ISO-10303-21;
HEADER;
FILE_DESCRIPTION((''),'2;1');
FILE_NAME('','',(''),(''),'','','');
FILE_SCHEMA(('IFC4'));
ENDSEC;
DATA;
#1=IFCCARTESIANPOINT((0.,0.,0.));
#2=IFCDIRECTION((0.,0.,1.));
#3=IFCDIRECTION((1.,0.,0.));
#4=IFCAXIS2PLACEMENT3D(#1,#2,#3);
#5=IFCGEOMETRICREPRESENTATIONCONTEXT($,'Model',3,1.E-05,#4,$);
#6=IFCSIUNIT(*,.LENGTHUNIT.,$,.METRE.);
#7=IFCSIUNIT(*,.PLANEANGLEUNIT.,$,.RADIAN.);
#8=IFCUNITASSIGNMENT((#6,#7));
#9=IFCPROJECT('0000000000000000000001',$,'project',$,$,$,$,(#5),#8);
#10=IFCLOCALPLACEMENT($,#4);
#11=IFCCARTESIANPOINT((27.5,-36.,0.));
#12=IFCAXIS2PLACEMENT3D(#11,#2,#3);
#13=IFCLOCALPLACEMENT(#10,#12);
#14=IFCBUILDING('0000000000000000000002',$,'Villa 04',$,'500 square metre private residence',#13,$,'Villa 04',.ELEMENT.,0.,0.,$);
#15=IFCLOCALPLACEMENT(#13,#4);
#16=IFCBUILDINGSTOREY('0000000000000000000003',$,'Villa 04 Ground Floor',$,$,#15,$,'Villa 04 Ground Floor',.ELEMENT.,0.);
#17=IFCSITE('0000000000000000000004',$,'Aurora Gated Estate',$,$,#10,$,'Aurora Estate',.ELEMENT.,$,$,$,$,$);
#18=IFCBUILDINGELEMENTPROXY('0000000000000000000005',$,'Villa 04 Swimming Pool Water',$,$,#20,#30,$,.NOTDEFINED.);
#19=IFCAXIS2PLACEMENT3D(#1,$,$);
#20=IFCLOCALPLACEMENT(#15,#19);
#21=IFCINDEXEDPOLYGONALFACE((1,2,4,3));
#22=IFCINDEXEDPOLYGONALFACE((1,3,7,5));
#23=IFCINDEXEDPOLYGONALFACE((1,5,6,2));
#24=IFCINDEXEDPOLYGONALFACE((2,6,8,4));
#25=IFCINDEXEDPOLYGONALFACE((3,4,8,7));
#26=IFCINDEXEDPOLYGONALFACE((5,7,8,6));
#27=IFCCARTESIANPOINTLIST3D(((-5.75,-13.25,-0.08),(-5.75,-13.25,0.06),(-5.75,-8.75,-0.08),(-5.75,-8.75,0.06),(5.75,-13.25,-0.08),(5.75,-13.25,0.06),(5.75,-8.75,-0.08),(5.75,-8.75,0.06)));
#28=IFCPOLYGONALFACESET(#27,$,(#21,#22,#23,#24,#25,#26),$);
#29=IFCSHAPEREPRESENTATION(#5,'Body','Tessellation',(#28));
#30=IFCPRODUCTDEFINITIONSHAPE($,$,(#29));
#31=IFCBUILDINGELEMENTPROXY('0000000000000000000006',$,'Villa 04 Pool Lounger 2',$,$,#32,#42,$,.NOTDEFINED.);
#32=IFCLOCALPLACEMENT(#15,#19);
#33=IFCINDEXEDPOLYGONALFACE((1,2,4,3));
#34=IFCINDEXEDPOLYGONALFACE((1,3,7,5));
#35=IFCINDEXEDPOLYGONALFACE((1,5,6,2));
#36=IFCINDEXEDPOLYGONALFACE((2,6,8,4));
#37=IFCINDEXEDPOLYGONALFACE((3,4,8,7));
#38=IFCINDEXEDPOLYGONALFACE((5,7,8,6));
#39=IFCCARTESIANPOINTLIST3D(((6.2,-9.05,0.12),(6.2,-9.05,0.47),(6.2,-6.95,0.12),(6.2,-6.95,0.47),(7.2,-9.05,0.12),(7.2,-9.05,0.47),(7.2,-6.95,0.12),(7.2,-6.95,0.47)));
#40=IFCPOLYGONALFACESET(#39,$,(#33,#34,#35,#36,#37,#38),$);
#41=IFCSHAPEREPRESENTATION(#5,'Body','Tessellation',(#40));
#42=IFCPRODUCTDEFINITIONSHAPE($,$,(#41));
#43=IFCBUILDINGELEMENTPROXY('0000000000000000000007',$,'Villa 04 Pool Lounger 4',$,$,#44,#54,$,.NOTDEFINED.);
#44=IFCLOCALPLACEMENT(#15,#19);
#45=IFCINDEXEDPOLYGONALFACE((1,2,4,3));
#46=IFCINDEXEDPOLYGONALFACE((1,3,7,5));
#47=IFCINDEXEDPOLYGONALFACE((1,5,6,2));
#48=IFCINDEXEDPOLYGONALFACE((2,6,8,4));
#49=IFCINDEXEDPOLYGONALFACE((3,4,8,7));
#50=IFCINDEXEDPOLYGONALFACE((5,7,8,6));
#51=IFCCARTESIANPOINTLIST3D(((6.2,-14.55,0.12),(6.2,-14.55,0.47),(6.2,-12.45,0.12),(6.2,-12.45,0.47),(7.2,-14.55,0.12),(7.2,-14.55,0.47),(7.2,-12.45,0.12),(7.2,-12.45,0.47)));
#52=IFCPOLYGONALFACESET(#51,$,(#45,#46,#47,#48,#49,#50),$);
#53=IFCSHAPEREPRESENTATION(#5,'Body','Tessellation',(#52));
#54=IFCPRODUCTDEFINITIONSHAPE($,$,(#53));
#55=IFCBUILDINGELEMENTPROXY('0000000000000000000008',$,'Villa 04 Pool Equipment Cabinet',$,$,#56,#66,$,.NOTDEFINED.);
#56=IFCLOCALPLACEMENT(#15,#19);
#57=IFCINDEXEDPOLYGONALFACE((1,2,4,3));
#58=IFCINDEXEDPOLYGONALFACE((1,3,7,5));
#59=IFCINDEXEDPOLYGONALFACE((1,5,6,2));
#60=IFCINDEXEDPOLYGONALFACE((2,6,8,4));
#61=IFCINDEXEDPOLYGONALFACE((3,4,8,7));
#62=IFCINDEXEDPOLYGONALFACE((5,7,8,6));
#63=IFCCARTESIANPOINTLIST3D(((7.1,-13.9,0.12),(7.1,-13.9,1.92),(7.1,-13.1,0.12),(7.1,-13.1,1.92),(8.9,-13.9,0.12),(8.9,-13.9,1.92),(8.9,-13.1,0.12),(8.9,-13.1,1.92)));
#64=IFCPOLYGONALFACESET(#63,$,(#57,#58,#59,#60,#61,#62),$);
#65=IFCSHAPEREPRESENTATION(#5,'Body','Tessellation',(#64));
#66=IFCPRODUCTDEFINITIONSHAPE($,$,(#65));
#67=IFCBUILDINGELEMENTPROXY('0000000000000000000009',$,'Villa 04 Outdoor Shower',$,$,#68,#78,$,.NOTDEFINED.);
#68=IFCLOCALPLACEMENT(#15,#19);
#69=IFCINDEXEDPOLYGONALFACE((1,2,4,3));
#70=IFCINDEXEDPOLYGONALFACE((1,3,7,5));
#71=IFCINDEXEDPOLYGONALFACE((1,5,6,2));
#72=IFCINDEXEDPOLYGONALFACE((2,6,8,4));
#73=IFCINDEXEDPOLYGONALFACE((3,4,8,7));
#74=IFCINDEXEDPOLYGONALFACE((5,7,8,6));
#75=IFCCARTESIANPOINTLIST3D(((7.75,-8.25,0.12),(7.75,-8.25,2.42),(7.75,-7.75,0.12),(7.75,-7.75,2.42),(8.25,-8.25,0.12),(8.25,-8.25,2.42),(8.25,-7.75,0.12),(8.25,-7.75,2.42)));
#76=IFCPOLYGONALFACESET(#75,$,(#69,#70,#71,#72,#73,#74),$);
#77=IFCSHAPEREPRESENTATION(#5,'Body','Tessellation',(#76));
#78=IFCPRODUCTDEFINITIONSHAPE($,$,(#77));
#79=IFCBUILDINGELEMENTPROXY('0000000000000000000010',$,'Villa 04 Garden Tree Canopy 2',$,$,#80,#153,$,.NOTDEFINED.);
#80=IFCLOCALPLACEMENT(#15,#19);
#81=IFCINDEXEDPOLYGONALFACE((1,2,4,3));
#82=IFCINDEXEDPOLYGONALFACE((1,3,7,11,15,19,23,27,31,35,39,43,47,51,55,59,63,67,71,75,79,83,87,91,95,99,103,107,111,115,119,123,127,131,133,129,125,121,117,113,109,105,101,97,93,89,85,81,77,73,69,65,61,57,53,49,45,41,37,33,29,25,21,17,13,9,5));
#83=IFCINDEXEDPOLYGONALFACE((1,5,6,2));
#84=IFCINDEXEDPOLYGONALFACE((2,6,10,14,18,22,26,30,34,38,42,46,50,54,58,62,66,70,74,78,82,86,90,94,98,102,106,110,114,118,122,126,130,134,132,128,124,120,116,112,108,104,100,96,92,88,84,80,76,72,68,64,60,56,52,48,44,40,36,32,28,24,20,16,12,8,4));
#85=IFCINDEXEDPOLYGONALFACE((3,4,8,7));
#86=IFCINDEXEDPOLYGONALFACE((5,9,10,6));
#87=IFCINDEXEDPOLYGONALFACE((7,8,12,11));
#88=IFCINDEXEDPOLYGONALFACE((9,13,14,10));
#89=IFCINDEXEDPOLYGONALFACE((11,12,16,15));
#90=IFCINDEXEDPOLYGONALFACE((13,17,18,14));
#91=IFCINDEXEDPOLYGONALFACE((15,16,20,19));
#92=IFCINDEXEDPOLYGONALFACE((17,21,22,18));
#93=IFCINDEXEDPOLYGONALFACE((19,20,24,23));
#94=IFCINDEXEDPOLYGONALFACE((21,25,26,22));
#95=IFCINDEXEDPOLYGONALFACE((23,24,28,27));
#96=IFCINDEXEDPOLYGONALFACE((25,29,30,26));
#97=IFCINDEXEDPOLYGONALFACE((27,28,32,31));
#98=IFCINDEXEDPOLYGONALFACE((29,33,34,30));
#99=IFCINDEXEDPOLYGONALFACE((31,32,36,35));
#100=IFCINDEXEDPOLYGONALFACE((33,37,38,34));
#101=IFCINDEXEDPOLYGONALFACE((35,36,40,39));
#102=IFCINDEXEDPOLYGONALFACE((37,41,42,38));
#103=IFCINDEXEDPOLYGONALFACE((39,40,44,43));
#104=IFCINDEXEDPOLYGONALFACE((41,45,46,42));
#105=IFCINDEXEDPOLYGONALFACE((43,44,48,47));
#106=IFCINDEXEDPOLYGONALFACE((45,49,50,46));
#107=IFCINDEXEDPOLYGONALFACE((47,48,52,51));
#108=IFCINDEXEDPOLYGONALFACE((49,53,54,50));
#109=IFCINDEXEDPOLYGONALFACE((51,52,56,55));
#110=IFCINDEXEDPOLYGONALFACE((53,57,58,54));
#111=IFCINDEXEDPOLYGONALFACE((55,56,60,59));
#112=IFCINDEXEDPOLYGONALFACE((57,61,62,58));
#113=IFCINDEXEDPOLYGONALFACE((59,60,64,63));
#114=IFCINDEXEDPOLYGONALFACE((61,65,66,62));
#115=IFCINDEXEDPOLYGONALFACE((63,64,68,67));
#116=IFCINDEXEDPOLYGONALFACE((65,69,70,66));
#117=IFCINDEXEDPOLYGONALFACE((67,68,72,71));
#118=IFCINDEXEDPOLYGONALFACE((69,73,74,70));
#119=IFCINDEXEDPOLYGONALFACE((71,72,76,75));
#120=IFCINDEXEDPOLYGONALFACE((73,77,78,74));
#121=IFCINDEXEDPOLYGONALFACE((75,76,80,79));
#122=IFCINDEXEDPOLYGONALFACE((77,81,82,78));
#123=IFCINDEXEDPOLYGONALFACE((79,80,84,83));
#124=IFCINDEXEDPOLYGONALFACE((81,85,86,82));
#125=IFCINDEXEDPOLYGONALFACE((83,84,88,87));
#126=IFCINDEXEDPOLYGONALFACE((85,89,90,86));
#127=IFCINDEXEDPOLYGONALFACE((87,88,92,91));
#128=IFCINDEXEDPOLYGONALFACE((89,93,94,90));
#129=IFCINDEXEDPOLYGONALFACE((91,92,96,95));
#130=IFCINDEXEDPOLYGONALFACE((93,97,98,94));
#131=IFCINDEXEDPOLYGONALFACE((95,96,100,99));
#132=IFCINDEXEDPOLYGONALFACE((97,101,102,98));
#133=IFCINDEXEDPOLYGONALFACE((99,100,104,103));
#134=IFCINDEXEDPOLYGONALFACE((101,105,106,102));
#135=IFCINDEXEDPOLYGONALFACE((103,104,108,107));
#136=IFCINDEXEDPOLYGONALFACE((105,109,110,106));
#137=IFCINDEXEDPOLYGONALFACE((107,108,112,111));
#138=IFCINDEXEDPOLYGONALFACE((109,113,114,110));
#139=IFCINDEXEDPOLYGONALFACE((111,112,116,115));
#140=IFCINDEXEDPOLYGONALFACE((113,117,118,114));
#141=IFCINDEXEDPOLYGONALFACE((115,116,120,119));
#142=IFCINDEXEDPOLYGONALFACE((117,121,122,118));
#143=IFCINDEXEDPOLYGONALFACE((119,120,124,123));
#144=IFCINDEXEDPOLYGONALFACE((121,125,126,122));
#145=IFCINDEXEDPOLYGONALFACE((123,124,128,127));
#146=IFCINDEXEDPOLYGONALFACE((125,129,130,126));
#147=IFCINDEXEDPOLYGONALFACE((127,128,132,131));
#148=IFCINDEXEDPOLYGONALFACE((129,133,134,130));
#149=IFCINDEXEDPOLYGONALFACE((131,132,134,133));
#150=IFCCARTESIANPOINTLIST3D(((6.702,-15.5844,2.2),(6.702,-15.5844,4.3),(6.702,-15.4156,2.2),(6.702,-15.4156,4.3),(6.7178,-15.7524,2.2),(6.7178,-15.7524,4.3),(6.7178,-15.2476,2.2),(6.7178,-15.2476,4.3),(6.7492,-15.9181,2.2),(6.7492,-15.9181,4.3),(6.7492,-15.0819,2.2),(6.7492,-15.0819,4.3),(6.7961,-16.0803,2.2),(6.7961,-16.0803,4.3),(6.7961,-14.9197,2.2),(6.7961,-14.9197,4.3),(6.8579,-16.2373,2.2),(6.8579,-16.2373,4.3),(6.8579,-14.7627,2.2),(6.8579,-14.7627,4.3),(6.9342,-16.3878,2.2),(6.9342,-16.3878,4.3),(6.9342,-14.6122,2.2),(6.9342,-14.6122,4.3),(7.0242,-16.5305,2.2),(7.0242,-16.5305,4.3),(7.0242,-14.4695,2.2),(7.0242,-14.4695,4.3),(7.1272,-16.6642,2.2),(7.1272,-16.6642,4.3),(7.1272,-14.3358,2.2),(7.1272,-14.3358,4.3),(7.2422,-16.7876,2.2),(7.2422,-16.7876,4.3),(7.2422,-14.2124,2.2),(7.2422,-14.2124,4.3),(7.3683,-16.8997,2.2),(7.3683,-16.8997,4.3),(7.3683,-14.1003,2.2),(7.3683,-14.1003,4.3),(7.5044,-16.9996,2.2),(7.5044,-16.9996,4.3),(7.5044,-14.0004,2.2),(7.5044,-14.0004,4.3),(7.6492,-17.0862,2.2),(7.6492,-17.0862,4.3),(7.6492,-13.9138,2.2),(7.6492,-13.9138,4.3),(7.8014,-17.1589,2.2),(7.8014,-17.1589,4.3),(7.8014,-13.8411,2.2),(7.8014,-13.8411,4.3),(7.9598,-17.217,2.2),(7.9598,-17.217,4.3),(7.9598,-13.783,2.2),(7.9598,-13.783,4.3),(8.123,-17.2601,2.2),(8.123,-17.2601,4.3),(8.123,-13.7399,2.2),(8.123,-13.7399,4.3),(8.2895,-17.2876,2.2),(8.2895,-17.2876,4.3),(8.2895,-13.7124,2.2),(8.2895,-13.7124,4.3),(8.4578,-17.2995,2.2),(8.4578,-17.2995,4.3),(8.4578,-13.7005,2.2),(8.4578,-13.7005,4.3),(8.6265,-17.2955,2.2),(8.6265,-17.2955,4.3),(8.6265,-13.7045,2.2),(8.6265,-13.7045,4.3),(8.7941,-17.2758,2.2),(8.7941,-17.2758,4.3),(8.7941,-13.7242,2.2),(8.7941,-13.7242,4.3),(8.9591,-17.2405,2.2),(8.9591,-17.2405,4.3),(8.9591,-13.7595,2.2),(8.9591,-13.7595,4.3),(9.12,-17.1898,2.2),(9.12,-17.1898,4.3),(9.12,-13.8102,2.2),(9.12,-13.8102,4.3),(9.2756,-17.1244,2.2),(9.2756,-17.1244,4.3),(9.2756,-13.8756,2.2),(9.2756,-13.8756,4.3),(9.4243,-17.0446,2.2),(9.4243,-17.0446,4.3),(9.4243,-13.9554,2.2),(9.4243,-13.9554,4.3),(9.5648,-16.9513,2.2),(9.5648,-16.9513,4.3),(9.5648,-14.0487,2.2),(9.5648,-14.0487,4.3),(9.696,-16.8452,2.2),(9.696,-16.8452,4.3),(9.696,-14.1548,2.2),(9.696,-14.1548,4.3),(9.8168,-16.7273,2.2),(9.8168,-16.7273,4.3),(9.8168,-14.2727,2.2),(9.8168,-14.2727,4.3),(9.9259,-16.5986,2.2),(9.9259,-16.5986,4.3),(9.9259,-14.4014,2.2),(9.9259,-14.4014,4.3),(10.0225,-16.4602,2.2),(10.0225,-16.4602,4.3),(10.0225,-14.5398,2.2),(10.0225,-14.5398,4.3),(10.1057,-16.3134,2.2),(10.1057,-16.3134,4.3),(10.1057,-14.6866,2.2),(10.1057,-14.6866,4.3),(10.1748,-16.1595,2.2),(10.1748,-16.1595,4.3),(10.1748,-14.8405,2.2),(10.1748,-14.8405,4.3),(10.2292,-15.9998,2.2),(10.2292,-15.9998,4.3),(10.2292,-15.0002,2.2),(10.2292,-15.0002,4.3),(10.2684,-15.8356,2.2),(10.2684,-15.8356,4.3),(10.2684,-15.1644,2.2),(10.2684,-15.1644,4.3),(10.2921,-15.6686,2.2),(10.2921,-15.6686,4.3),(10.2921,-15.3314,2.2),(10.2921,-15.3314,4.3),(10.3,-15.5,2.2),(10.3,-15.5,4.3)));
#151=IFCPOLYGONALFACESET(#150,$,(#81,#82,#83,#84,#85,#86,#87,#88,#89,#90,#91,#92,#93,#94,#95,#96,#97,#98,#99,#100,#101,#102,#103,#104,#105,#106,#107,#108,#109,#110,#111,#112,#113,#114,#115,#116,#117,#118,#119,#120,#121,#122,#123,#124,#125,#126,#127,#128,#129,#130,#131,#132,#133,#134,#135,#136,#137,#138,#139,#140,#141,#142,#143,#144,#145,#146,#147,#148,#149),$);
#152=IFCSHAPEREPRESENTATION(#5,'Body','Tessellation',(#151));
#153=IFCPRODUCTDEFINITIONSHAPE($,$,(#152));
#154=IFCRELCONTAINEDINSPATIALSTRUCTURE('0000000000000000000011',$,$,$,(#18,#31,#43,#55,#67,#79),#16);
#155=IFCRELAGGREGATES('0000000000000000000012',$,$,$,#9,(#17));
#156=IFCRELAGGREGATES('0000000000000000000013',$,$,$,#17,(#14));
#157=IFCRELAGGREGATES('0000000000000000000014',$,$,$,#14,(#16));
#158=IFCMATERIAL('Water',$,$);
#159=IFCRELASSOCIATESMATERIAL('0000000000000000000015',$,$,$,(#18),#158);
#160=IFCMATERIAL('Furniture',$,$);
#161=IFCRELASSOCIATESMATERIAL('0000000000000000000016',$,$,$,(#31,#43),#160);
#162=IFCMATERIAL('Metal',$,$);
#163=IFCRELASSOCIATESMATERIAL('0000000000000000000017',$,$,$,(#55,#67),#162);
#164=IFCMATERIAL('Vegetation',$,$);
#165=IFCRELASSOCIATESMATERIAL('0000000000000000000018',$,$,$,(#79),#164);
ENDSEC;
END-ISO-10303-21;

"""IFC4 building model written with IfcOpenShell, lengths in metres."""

from ifc_helpers import new_model, si_unit, frame, origin_with_axes, origin_2d_with_axis, place, context, project, spatial, rectangle, circle, extrude, material, element, save


model = new_model("IFC4")

# Units and contexts
model_context = context("Model", 3, precision=1e-05, world=origin_with_axes())
ifc_project = project(units=[si_unit("LENGTHUNIT", "METRE"), si_unit("PLANEANGLEUNIT", "RADIAN")], contexts=[model_context])

# Site, building, storey
site_placement = place(None, origin_with_axes())
site = spatial("IfcSite", under=ifc_project, at=site_placement, Name="Aurora Gated Estate", LongName="Aurora Estate", CompositionType="ELEMENT")
building_placement = place(site_placement, frame((27.5, -36.0, 0.0), z_axis=(0.0, 0.0, 1.0), x_axis=(1.0, 0.0, 0.0)))
building = spatial("IfcBuilding", under=site, at=building_placement, Name="Villa 04", ObjectType="500 square metre private residence", LongName="Villa 04", CompositionType="ELEMENT", ElevationOfRefHeight=0.0, ElevationOfTerrain=0.0)
storey_placement = place(building_placement, origin_with_axes())
storey = spatial("IfcBuildingStorey", under=building, at=storey_placement, Name="Villa 04 Ground Floor", LongName="Villa 04 Ground Floor", CompositionType="ELEMENT", Elevation=0.0)

# Building element proxies
ifc_material_1 = material(Name="Furniture")
ifc_material_2 = material(Name="Water")
proxy_1_placement = place(storey_placement, frame((0.0, -11.0, -0.08), z_axis=(0.0, 0.0, 1.0), x_axis=(1.0, 0.0, 0.0)))
element("IfcBuildingElementProxy", 1, at=proxy_1_placement, inside=storey, material=ifc_material_2, Name="Villa 04 Swimming Pool Water", PredefinedType="NOTDEFINED", context=model_context, shape_type="SweptSolid", body=[
    extrude(rectangle(XDim=11.5, YDim=4.5, at=origin_2d_with_axis()), origin_with_axes(), (0.0, 0.0, 1.0), 0.14),
])
for number, where, z_axis, x_axis, name in (
    (2, (6.7, -8.0, 0.12), (0.0, 0.0, 1.0), (1.0, 0.0, 0.0), "Villa 04 Pool Lounger 2"),
    (3, (6.7, -13.5, 0.12), (0.0, 0.0, 1.0), (1.0, 0.0, 0.0), "Villa 04 Pool Lounger 4"),
):
    element("IfcBuildingElementProxy", number, at=place(storey_placement, frame(where, z_axis=z_axis, x_axis=x_axis)), inside=storey, material=ifc_material_1, Name=name, PredefinedType="NOTDEFINED", context=model_context, shape_type="SweptSolid", body=[
        extrude(rectangle(XDim=1.0, YDim=2.1, at=origin_2d_with_axis()), origin_with_axes(), (0.0, 0.0, 1.0), 0.35),
    ])
ifc_material_3 = material(Name="Metal")
proxy_2_placement = place(storey_placement, frame((8.0, -13.5, 0.12), z_axis=(0.0, 0.0, 1.0), x_axis=(1.0, 0.0, 0.0)))
element("IfcBuildingElementProxy", 4, at=proxy_2_placement, inside=storey, material=ifc_material_3, Name="Villa 04 Pool Equipment Cabinet", PredefinedType="NOTDEFINED", context=model_context, shape_type="SweptSolid", body=[
    extrude(rectangle(XDim=1.8, YDim=0.8, at=origin_2d_with_axis()), origin_with_axes(), (0.0, 0.0, 1.0), 1.8),
])
proxy_3_placement = place(storey_placement, frame((8.0, -8.0, 0.12), z_axis=(0.0, 0.0, 1.0), x_axis=(1.0, 0.0, 0.0)))
element("IfcBuildingElementProxy", 5, at=proxy_3_placement, inside=storey, material=ifc_material_3, Name="Villa 04 Outdoor Shower", PredefinedType="NOTDEFINED", context=model_context, shape_type="SweptSolid", body=[
    extrude(rectangle(XDim=0.5, YDim=0.5, at=origin_2d_with_axis()), origin_with_axes(), (0.0, 0.0, 1.0), 2.3),
])
ifc_material_4 = material(Name="Vegetation")
proxy_4_placement = place(storey_placement, frame((8.5, -15.5, 2.2), z_axis=(0.0, 0.0, 1.0), x_axis=(1.0, 0.0, 0.0)))
element("IfcBuildingElementProxy", 6, at=proxy_4_placement, inside=storey, material=ifc_material_4, Name="Villa 04 Garden Tree Canopy 2", PredefinedType="NOTDEFINED", context=model_context, shape_type="SweptSolid", body=[
    extrude(circle(Radius=1.8, at=origin_2d_with_axis()), origin_with_axes(), (0.0, 0.0, 1.0), 2.1),
])

save(model, "model.ifc")
